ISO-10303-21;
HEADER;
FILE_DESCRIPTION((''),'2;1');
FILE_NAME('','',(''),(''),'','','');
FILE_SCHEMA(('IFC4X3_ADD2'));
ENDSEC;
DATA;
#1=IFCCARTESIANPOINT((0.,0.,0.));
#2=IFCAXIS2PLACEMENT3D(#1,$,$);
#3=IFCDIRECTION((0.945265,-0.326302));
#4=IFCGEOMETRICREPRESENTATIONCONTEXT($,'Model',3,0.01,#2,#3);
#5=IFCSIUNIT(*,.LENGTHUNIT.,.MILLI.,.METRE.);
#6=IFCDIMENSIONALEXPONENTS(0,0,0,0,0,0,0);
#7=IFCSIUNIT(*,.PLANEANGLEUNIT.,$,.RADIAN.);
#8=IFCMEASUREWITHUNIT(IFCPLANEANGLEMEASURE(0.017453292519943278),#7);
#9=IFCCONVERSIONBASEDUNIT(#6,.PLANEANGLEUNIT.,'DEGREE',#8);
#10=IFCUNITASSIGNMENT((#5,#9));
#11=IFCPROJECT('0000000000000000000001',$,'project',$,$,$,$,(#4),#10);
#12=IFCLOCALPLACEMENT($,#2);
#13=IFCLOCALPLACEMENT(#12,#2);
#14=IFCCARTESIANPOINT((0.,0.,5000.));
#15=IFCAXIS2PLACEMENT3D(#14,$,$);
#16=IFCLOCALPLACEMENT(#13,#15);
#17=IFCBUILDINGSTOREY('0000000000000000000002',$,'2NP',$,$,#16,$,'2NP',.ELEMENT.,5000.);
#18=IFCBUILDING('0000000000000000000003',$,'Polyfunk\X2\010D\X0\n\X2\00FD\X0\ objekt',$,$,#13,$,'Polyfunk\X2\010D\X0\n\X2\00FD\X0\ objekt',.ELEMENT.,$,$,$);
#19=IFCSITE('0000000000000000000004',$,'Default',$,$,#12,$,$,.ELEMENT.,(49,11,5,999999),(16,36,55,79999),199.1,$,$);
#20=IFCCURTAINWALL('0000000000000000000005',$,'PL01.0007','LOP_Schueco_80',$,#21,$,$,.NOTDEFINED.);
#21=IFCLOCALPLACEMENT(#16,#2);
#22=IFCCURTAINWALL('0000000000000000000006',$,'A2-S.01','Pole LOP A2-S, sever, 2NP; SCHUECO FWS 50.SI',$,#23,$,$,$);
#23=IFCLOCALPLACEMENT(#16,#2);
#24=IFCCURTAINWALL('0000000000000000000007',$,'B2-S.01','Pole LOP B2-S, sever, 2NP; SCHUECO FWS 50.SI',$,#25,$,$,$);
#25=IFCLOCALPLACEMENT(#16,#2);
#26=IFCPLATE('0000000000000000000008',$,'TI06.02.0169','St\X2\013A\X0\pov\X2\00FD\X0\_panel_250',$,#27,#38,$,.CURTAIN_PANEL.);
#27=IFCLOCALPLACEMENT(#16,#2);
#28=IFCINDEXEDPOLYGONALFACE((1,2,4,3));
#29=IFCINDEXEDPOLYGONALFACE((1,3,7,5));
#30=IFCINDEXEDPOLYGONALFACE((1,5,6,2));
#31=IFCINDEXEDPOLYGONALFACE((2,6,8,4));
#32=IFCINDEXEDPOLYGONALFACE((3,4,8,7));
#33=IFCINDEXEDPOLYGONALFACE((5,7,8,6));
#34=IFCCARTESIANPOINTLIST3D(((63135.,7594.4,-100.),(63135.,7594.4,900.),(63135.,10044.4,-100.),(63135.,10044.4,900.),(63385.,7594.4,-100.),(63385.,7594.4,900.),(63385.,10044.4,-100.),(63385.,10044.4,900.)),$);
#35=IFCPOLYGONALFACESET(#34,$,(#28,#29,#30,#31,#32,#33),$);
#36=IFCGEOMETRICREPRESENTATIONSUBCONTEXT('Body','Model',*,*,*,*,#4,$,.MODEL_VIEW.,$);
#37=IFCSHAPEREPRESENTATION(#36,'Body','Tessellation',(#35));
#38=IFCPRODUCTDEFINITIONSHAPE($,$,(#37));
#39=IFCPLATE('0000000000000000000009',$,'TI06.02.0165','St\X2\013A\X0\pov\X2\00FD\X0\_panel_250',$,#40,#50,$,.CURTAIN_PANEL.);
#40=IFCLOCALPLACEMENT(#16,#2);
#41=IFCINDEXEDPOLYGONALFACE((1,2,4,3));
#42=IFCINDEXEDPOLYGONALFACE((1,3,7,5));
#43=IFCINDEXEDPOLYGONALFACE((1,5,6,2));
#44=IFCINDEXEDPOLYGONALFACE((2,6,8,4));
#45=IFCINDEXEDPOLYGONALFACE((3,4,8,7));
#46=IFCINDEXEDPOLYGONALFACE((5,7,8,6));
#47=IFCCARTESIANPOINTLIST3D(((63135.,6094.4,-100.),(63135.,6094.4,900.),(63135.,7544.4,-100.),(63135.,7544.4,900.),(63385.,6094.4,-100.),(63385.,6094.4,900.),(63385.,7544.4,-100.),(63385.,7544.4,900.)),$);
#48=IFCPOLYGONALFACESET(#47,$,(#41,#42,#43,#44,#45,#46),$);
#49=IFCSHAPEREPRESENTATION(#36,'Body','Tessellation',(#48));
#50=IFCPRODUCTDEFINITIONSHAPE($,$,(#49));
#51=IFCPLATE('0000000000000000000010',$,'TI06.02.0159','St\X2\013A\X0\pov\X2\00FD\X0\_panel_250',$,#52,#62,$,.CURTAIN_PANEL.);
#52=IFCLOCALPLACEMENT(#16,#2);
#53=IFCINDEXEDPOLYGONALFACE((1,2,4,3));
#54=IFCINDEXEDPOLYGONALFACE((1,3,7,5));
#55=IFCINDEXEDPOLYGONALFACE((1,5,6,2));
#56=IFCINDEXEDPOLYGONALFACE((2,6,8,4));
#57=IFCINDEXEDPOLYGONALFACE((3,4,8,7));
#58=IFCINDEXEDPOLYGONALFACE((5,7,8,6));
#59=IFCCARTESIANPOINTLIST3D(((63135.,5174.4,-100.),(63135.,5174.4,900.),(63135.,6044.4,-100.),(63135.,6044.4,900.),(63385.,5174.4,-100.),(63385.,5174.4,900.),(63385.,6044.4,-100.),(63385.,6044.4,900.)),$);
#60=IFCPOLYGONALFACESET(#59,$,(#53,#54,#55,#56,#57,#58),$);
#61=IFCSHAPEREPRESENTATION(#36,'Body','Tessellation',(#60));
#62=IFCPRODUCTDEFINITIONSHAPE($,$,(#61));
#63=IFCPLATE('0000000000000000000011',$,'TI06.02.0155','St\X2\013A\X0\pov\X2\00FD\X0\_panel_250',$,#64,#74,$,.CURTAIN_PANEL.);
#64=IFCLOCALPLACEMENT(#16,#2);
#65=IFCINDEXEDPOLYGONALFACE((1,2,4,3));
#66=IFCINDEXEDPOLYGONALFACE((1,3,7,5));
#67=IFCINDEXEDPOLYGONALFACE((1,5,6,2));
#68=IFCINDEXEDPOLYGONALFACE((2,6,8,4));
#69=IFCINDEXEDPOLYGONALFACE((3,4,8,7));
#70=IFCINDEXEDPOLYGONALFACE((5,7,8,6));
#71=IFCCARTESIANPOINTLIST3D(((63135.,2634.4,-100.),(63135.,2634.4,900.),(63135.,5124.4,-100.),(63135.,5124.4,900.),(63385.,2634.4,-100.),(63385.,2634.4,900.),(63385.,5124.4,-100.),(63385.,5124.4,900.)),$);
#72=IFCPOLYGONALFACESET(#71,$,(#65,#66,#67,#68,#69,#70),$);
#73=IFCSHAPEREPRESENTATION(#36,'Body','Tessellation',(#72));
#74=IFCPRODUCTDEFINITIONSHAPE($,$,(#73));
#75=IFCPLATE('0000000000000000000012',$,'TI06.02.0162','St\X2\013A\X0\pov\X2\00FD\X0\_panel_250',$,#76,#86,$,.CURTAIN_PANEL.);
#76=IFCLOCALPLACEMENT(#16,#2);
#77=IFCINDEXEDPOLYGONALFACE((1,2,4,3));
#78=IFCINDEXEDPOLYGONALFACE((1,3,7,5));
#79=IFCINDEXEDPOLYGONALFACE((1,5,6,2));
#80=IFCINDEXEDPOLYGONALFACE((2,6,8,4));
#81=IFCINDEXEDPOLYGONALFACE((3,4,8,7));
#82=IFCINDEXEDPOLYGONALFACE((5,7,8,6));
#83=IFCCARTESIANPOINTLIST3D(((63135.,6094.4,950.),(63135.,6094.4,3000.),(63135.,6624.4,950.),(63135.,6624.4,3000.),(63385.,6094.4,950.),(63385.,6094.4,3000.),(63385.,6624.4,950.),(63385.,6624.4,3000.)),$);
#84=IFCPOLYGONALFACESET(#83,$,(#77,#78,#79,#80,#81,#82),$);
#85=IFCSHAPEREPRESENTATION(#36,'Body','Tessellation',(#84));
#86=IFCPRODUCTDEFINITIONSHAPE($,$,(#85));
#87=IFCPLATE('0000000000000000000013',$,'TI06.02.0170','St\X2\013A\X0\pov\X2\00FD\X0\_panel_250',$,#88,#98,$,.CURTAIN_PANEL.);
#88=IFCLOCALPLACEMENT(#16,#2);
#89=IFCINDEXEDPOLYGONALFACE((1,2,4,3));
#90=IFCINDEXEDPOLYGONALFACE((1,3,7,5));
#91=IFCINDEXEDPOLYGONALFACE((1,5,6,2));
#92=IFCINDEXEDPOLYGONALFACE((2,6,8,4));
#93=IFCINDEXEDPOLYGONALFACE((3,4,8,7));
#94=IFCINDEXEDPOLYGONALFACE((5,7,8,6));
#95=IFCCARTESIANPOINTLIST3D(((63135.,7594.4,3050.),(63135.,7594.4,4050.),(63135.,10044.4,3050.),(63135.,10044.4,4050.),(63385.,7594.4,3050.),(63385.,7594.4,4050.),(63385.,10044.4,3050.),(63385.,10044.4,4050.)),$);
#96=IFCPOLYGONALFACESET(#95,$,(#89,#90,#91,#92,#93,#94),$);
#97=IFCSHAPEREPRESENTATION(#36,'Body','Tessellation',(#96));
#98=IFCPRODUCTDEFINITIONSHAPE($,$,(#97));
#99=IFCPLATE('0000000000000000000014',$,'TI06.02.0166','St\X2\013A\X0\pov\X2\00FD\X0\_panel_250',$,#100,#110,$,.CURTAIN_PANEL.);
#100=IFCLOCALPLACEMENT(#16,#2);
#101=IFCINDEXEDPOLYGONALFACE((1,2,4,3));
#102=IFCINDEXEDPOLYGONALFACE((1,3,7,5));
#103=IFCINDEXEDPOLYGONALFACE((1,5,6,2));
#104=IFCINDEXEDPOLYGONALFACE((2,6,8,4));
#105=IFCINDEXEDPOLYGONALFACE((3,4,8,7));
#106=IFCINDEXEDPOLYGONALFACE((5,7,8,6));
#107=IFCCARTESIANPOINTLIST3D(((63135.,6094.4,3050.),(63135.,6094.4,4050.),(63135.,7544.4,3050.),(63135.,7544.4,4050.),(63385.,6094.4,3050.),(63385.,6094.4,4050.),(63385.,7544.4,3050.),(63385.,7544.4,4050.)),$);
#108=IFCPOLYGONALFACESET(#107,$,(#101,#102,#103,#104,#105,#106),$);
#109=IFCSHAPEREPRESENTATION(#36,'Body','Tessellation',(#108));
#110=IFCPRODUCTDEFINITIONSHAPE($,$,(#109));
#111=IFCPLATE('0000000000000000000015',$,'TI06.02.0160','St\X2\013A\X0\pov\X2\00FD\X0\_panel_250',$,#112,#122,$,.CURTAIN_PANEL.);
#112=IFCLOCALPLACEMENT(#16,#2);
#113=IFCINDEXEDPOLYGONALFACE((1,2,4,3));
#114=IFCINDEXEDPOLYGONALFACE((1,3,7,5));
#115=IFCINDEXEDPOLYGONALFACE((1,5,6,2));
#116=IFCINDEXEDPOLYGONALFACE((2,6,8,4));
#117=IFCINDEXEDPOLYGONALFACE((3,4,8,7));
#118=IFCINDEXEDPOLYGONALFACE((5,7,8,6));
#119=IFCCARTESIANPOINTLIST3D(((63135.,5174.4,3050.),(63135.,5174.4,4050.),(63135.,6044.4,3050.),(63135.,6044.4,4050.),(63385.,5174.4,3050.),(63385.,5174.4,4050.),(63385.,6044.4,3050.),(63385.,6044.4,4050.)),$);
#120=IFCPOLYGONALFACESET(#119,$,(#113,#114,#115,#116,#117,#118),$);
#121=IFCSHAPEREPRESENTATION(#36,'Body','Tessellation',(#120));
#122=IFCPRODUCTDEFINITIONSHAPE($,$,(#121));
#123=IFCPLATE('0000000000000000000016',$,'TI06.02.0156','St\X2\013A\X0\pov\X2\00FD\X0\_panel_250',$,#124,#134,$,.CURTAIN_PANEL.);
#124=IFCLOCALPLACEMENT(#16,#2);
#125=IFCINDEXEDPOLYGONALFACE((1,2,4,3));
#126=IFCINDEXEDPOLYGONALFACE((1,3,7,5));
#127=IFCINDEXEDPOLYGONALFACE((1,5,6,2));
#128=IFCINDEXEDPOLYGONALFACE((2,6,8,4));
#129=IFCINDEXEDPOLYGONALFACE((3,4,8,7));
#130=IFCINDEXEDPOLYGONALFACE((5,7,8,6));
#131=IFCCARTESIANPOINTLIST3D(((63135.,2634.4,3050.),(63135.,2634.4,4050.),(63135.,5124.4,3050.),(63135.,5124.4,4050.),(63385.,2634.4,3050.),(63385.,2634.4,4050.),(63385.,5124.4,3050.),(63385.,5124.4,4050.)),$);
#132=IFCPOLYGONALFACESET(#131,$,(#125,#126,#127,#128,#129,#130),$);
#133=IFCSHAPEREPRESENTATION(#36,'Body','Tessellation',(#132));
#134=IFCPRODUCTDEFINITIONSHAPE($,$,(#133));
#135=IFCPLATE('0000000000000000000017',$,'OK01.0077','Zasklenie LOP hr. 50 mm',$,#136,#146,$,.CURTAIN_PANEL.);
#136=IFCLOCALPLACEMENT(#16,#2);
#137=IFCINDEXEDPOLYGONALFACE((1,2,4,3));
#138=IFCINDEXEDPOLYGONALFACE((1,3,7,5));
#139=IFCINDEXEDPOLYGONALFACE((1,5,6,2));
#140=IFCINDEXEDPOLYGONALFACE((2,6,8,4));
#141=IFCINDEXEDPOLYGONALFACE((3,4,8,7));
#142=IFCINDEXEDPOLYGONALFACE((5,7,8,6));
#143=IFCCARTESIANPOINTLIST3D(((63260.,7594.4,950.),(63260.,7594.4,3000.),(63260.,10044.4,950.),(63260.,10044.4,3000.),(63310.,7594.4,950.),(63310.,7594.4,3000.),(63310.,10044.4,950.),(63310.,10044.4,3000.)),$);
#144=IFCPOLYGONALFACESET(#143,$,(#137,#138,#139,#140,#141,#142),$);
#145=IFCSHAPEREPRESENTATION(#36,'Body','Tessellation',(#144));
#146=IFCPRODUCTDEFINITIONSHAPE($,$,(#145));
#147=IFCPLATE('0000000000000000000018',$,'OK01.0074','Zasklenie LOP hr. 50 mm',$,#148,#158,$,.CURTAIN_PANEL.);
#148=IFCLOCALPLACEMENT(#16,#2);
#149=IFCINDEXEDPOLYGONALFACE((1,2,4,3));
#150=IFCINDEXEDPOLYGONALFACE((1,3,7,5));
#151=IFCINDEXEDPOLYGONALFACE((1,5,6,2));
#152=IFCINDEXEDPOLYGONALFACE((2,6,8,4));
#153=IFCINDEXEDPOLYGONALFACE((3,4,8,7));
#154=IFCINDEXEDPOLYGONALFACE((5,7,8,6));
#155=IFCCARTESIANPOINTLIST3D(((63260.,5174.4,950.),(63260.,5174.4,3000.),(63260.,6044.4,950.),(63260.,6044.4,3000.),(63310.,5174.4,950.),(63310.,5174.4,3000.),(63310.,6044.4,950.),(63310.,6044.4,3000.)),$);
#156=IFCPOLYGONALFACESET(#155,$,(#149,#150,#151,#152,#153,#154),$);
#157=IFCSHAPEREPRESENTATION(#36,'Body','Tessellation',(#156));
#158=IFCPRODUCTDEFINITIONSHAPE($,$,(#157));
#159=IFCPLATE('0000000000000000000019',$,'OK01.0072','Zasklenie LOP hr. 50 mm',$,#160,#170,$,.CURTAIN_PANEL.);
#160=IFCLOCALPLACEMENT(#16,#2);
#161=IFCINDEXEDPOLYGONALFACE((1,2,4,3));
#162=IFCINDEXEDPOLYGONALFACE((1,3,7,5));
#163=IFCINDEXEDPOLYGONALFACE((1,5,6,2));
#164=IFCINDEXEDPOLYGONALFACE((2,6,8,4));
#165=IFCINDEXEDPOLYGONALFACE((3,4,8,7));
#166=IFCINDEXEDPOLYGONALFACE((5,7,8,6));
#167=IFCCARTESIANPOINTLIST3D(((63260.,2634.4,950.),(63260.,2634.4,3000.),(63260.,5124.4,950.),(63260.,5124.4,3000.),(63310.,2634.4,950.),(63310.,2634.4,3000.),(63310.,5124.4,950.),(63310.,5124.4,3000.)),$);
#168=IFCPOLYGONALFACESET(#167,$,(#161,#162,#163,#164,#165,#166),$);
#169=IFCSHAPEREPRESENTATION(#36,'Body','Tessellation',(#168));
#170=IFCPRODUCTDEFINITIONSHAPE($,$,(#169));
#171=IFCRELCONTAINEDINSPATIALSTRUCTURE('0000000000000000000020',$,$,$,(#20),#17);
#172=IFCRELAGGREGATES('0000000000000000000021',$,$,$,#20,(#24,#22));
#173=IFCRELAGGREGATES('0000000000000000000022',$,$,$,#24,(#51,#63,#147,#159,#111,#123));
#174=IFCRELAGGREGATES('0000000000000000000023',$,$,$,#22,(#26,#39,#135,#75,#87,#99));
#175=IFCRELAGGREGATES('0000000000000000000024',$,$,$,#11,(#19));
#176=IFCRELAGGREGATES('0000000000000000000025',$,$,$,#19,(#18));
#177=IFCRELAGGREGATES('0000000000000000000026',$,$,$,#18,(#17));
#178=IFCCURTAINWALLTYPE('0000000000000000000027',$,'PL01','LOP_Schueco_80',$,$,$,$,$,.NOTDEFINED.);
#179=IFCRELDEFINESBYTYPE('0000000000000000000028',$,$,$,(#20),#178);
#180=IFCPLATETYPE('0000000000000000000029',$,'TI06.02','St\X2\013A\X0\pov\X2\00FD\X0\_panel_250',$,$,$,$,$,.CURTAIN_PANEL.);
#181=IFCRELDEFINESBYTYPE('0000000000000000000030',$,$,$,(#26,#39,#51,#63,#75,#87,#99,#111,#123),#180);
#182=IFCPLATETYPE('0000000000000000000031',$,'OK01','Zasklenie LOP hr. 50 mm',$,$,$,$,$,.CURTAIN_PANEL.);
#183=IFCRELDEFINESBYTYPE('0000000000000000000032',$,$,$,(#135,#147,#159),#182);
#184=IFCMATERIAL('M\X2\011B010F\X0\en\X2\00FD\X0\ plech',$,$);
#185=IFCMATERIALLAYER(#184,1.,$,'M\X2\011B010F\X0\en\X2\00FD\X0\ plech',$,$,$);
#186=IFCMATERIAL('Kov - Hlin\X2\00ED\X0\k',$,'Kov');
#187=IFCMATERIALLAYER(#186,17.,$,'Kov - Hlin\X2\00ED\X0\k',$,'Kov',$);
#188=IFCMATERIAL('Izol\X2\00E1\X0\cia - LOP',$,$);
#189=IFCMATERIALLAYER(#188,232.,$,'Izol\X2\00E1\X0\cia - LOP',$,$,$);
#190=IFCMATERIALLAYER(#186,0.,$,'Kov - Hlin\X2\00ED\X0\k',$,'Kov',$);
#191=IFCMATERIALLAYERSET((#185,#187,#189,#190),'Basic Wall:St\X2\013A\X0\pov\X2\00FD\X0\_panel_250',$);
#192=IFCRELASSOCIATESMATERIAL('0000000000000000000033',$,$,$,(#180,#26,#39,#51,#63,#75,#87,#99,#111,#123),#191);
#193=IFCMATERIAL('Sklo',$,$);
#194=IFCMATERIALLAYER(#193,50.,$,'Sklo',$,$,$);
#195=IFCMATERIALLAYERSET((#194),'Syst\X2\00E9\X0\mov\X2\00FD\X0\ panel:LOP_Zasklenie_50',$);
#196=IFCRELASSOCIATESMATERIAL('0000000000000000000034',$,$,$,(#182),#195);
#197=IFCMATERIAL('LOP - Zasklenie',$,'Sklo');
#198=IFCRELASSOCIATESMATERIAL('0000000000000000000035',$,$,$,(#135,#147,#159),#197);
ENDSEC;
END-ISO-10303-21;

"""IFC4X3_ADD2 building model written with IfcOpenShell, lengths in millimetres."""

from ifc_helpers import new_model, entity, si_unit, converted_unit, direction, frame, frame_2d, origin, origin_2d_with_axis, place, context, subcontext, project, spatial, rectangle, extrude, source, transform, mapped, material, layer, layer_set, layer_usage, type_object, type_shapes, element, aggregate, save


model = new_model("IFC4X3_ADD2")

# Units and contexts
model_context = context("Model", 3, precision=0.01, world=origin(), true_north=direction((0.945265, -0.326302)))
body_context = subcontext(model_context, "Body", "Model", "MODEL_VIEW")
ifc_project = project(units=[si_unit("LENGTHUNIT", "METRE", prefix="MILLI"), converted_unit("PLANEANGLEUNIT", "DEGREE", entity("IfcPlaneAngleMeasure", 0.017453292519943278), si_unit("PLANEANGLEUNIT", "RADIAN"), dimensions=[0, 0, 0, 0, 0, 0, 0])], contexts=[model_context])

# Site, building, storey
site_placement = place(None, origin())
site = spatial("IfcSite", under=ifc_project, at=site_placement, Name="Default", CompositionType="ELEMENT", RefLatitude=(49, 11, 5, 999999), RefLongitude=(16, 36, 55, 79999), RefElevation=199.1)
building_placement = place(site_placement, origin())
building = spatial("IfcBuilding", under=site, at=building_placement, Name="Polyfunkčný objekt", LongName="Polyfunkčný objekt", CompositionType="ELEMENT")
storey_placement = place(building_placement, frame((0.0, 0.0, 5000.0)))
storey = spatial("IfcBuildingStorey", under=building, at=storey_placement, Name="2NP", LongName="2NP", CompositionType="ELEMENT", Elevation=5000.0)

# Curtain walls, plates
curtain_wall_type = type_object("IfcCurtainWallType", Name="PL01", Description="LOP_Schueco_80", PredefinedType="NOTDEFINED")
curtain_wall_1_placement = place(storey_placement, frame((0.0, 0.0, -5000.0)))
curtain_wall_1 = element("IfcCurtainWall", 1, at=curtain_wall_1_placement, inside=storey, type_object=curtain_wall_type, Name="PL01.0007", Description="LOP_Schueco_80", PredefinedType="NOTDEFINED")
curtain_wall_2 = element("IfcCurtainWall", 2, Name="A2-S.01", Description="Pole LOP A2-S, sever, 2NP; SCHUECO FWS 50.SI")
curtain_wall_3 = element("IfcCurtainWall", 3, Name="B2-S.01", Description="Pole LOP B2-S, sever, 2NP; SCHUECO FWS 50.SI")
aggregate(curtain_wall_1, [curtain_wall_3, curtain_wall_2])
ifc_material_1 = material(Name="Měďený plech")
ifc_layer_1 = layer(ifc_material_1, 1.0, Name="Měďený plech")
ifc_material_2 = material(Name="Kov - Hliník", Category="Kov")
ifc_layer_2 = layer(ifc_material_2, 17.0, Name="Kov - Hliník", Category="Kov")
ifc_material_3 = material(Name="Izolácia - LOP")
ifc_layer_3 = layer(ifc_material_3, 232.0, Name="Izolácia - LOP")
ifc_layer_4 = layer(ifc_material_2, 0.0, Name="Kov - Hliník", Category="Kov")
ifc_layer_set_1 = layer_set([ifc_layer_1, ifc_layer_2, ifc_layer_3, ifc_layer_4], Name="Basic Wall:Stĺpový_panel_250")
ifc_layer_usage_1 = layer_usage(ifc_layer_set_1, "AXIS2", "NEGATIVE", 125.0)
plate_type_1 = type_object("IfcPlateType", Name="TI06.02", Description="Stĺpový_panel_250", PredefinedType="CURTAIN_PANEL", material=ifc_layer_set_1)
plate_1_placement = place(storey_placement, frame((63260.0, 10044.4, -100.0), z_axis=(0.0, 0.0, 1.0), x_axis=(0.0, -1.0, 0.0)))
plate_1 = element("IfcPlate", 4, at=plate_1_placement, type_object=plate_type_1, material=ifc_layer_usage_1, Name="TI06.02.0169", Description="Stĺpový_panel_250", PredefinedType="CURTAIN_PANEL", context=body_context, shape_type="SweptSolid", body=[
    extrude(rectangle(XDim=250.0, YDim=2450.0, at=origin_2d_with_axis()), frame((1225.0, 0.0, 0.0), z_axis=(0.0, 0.0, 1.0), x_axis=(0.0, 1.0, 0.0)), (0.0, 0.0, 1.0), 1000.0),
])
ifc_layer_usage_2 = layer_usage(ifc_layer_set_1, "AXIS2", "NEGATIVE", 125.0)
plate_2_placement = place(storey_placement, frame((63260.0, 7544.4, -100.0), z_axis=(0.0, 0.0, 1.0), x_axis=(0.0, -1.0, 0.0)))
plate_2 = element("IfcPlate", 5, at=plate_2_placement, type_object=plate_type_1, material=ifc_layer_usage_2, Name="TI06.02.0165", Description="Stĺpový_panel_250", PredefinedType="CURTAIN_PANEL", context=body_context, shape_type="SweptSolid", body=[
    extrude(rectangle(XDim=250.0, YDim=1450.0, at=frame_2d((0.0, 0.0), x_axis=(1.0, 0.0))), frame((725.0, 0.0, 0.0), z_axis=(0.0, 0.0, 1.0), x_axis=(0.0, 1.0, 0.0)), (0.0, 0.0, 1.0), 1000.0),
])
ifc_layer_usage_3 = layer_usage(ifc_layer_set_1, "AXIS2", "NEGATIVE", 125.0)
plate_3_placement = place(storey_placement, frame((63260.0, 6044.4, -100.0), z_axis=(0.0, 0.0, 1.0), x_axis=(0.0, -1.0, 0.0)))
plate_3 = element("IfcPlate", 6, at=plate_3_placement, type_object=plate_type_1, material=ifc_layer_usage_3, Name="TI06.02.0159", Description="Stĺpový_panel_250", PredefinedType="CURTAIN_PANEL", context=body_context, shape_type="SweptSolid", body=[
    extrude(rectangle(XDim=250.0, YDim=870.0, at=frame_2d((0.0, 0.0), x_axis=(1.0, 0.0))), frame((435.0, 0.0, 0.0), z_axis=(0.0, 0.0, 1.0), x_axis=(0.0, 1.0, 0.0)), (0.0, 0.0, 1.0), 1000.0),
])
ifc_layer_usage_4 = layer_usage(ifc_layer_set_1, "AXIS2", "NEGATIVE", 125.0)
plate_4_placement = place(storey_placement, frame((63260.0, 5124.4, -100.0), z_axis=(0.0, 0.0, 1.0), x_axis=(0.0, -1.0, 0.0)))
plate_4 = element("IfcPlate", 7, at=plate_4_placement, type_object=plate_type_1, material=ifc_layer_usage_4, Name="TI06.02.0155", Description="Stĺpový_panel_250", PredefinedType="CURTAIN_PANEL", context=body_context, shape_type="SweptSolid", body=[
    extrude(rectangle(XDim=250.0, YDim=2490.0, at=origin_2d_with_axis()), frame((1245.0, 0.0, 0.0), z_axis=(0.0, 0.0, 1.0), x_axis=(0.0, 1.0, 0.0)), (0.0, 0.0, 1.0), 1000.0),
])
ifc_layer_usage_5 = layer_usage(ifc_layer_set_1, "AXIS2", "NEGATIVE", 125.0)
plate_5_placement = place(storey_placement, frame((63260.0, 6624.4, 950.0), z_axis=(0.0, 0.0, 1.0), x_axis=(0.0, -1.0, 0.0)))
plate_5 = element("IfcPlate", 8, at=plate_5_placement, type_object=plate_type_1, material=ifc_layer_usage_5, Name="TI06.02.0162", Description="Stĺpový_panel_250", PredefinedType="CURTAIN_PANEL", context=body_context, shape_type="SweptSolid", body=[
    extrude(rectangle(XDim=250.0, YDim=530.0, at=frame_2d((0.0, 0.0), x_axis=(1.0, 0.0))), frame((265.0, 0.0, 0.0), z_axis=(0.0, 0.0, 1.0), x_axis=(0.0, 1.0, 0.0)), (0.0, 0.0, 1.0), 2050.0),
])
ifc_layer_usage_6 = layer_usage(ifc_layer_set_1, "AXIS2", "NEGATIVE", 125.0)
plate_6_placement = place(storey_placement, frame((63260.0, 10044.4, 3050.0), z_axis=(0.0, 0.0, 1.0), x_axis=(0.0, -1.0, 0.0)))
plate_6 = element("IfcPlate", 9, at=plate_6_placement, type_object=plate_type_1, material=ifc_layer_usage_6, Name="TI06.02.0170", Description="Stĺpový_panel_250", PredefinedType="CURTAIN_PANEL", context=body_context, shape_type="SweptSolid", body=[
    extrude(rectangle(XDim=250.0, YDim=2450.0, at=frame_2d((0.0, 0.0), x_axis=(1.0, 0.0))), frame((1225.0, 0.0, 0.0), z_axis=(0.0, 0.0, 1.0), x_axis=(0.0, 1.0, 0.0)), (0.0, 0.0, 1.0), 1000.0),
])
ifc_layer_usage_7 = layer_usage(ifc_layer_set_1, "AXIS2", "NEGATIVE", 125.0)
plate_7_placement = place(storey_placement, frame((63260.0, 7544.4, 3050.0), z_axis=(0.0, 0.0, 1.0), x_axis=(0.0, -1.0, 0.0)))
plate_7 = element("IfcPlate", 10, at=plate_7_placement, type_object=plate_type_1, material=ifc_layer_usage_7, Name="TI06.02.0166", Description="Stĺpový_panel_250", PredefinedType="CURTAIN_PANEL", context=body_context, shape_type="SweptSolid", body=[
    extrude(rectangle(XDim=250.0, YDim=1450.0, at=frame_2d((0.0, 0.0), x_axis=(1.0, 0.0))), frame((725.0, 0.0, 0.0), z_axis=(0.0, 0.0, 1.0), x_axis=(0.0, 1.0, 0.0)), (0.0, 0.0, 1.0), 1000.0),
])
ifc_layer_usage_8 = layer_usage(ifc_layer_set_1, "AXIS2", "NEGATIVE", 125.0)
plate_8_placement = place(storey_placement, frame((63260.0, 6044.4, 3050.0), z_axis=(0.0, 0.0, 1.0), x_axis=(0.0, -1.0, 0.0)))
plate_8 = element("IfcPlate", 11, at=plate_8_placement, type_object=plate_type_1, material=ifc_layer_usage_8, Name="TI06.02.0160", Description="Stĺpový_panel_250", PredefinedType="CURTAIN_PANEL", context=body_context, shape_type="SweptSolid", body=[
    extrude(rectangle(XDim=250.0, YDim=870.0, at=frame_2d((0.0, 0.0), x_axis=(1.0, 0.0))), frame((435.0, 0.0, 0.0), z_axis=(0.0, 0.0, 1.0), x_axis=(0.0, 1.0, 0.0)), (0.0, 0.0, 1.0), 1000.0),
])
ifc_layer_usage_9 = layer_usage(ifc_layer_set_1, "AXIS2", "NEGATIVE", 125.0)
plate_9_placement = place(storey_placement, frame((63260.0, 5124.4, 3050.0), z_axis=(0.0, 0.0, 1.0), x_axis=(0.0, -1.0, 0.0)))
plate_9 = element("IfcPlate", 12, at=plate_9_placement, type_object=plate_type_1, material=ifc_layer_usage_9, Name="TI06.02.0156", Description="Stĺpový_panel_250", PredefinedType="CURTAIN_PANEL", context=body_context, shape_type="SweptSolid", body=[
    extrude(rectangle(XDim=250.0, YDim=2490.0, at=frame_2d((0.0, 0.0), x_axis=(1.0, 0.0))), frame((1245.0, 0.0, 0.0), z_axis=(0.0, 0.0, 1.0), x_axis=(0.0, 1.0, 0.0)), (0.0, 0.0, 1.0), 1000.0),
])
ifc_material_4 = material(Name="LOP - Zasklenie", Category="Sklo")
ifc_material_5 = material(Name="Sklo")
ifc_layer_5 = layer(ifc_material_5, 50.0, Name="Sklo")
ifc_layer_set_2 = layer_set([ifc_layer_5], Name="Systémový panel:LOP_Zasklenie_50")
plate_type_2 = type_object("IfcPlateType", Name="OK01", Description="Zasklenie LOP hr. 50 mm", PredefinedType="CURTAIN_PANEL", material=ifc_layer_set_2)
shared_shape_1 = source(origin(), body_context, "Body", "SweptSolid", [
    extrude(rectangle(XDim=50.0, YDim=2450.0, at=origin_2d_with_axis()), frame((0.0, 25.0, 0.0), z_axis=(0.0, 0.0, 1.0), x_axis=(0.0, 1.0, 0.0)), (0.0, 0.0, 1.0), 2050.0),
])
plate_10_placement = place(curtain_wall_1_placement, frame((63260.0, 8819.4, 5950.0), z_axis=(0.0, 0.0, 1.0), x_axis=(0.0, -1.0, 0.0)))
plate_10 = element("IfcPlate", 13, at=plate_10_placement, type_object=plate_type_2, material=ifc_material_4, Name="OK01.0077", Description="Zasklenie LOP hr. 50 mm", PredefinedType="CURTAIN_PANEL", context=body_context, shape_type="MappedRepresentation", body=[
    mapped(shared_shape_1, transform((0.0, 0.0, 0.0), scale=1.0)),
])
shared_shape_2 = source(origin(), body_context, "Body", "SweptSolid", [
    extrude(rectangle(XDim=50.0, YDim=870.0, at=origin_2d_with_axis()), frame((0.0, 25.0, 0.0), z_axis=(0.0, 0.0, 1.0), x_axis=(0.0, 1.0, 0.0)), (0.0, 0.0, 1.0), 2050.0),
])
plate_11_placement = place(curtain_wall_1_placement, frame((63260.0, 5609.4, 5950.0), z_axis=(0.0, 0.0, 1.0), x_axis=(0.0, -1.0, 0.0)))
plate_11 = element("IfcPlate", 14, at=plate_11_placement, type_object=plate_type_2, material=ifc_material_4, Name="OK01.0074", Description="Zasklenie LOP hr. 50 mm", PredefinedType="CURTAIN_PANEL", context=body_context, shape_type="MappedRepresentation", body=[
    mapped(shared_shape_2, transform((0.0, 0.0, 0.0), scale=1.0)),
])
shared_shape_3 = source(origin(), body_context, "Body", "SweptSolid", [
    extrude(rectangle(XDim=50.0, YDim=2490.0, at=origin_2d_with_axis()), frame((0.0, 25.0, 0.0), z_axis=(0.0, 0.0, 1.0), x_axis=(0.0, 1.0, 0.0)), (0.0, 0.0, 1.0), 2050.0),
])
type_shapes(plate_type_2, [shared_shape_1, shared_shape_2, shared_shape_3])
plate_12_placement = place(curtain_wall_1_placement, frame((63260.0, 3879.4, 5950.0), z_axis=(0.0, 0.0, 1.0), x_axis=(0.0, -1.0, 0.0)))
plate_12 = element("IfcPlate", 15, at=plate_12_placement, type_object=plate_type_2, material=ifc_material_4, Name="OK01.0072", Description="Zasklenie LOP hr. 50 mm", PredefinedType="CURTAIN_PANEL", context=body_context, shape_type="MappedRepresentation", body=[
    mapped(shared_shape_3, transform((0.0, 0.0, 0.0), scale=1.0)),
])
aggregate(curtain_wall_3, [plate_3, plate_4, plate_11, plate_12, plate_8, plate_9])
aggregate(curtain_wall_2, [plate_1, plate_2, plate_10, plate_5, plate_6, plate_7])

save(model, "model.ifc")
